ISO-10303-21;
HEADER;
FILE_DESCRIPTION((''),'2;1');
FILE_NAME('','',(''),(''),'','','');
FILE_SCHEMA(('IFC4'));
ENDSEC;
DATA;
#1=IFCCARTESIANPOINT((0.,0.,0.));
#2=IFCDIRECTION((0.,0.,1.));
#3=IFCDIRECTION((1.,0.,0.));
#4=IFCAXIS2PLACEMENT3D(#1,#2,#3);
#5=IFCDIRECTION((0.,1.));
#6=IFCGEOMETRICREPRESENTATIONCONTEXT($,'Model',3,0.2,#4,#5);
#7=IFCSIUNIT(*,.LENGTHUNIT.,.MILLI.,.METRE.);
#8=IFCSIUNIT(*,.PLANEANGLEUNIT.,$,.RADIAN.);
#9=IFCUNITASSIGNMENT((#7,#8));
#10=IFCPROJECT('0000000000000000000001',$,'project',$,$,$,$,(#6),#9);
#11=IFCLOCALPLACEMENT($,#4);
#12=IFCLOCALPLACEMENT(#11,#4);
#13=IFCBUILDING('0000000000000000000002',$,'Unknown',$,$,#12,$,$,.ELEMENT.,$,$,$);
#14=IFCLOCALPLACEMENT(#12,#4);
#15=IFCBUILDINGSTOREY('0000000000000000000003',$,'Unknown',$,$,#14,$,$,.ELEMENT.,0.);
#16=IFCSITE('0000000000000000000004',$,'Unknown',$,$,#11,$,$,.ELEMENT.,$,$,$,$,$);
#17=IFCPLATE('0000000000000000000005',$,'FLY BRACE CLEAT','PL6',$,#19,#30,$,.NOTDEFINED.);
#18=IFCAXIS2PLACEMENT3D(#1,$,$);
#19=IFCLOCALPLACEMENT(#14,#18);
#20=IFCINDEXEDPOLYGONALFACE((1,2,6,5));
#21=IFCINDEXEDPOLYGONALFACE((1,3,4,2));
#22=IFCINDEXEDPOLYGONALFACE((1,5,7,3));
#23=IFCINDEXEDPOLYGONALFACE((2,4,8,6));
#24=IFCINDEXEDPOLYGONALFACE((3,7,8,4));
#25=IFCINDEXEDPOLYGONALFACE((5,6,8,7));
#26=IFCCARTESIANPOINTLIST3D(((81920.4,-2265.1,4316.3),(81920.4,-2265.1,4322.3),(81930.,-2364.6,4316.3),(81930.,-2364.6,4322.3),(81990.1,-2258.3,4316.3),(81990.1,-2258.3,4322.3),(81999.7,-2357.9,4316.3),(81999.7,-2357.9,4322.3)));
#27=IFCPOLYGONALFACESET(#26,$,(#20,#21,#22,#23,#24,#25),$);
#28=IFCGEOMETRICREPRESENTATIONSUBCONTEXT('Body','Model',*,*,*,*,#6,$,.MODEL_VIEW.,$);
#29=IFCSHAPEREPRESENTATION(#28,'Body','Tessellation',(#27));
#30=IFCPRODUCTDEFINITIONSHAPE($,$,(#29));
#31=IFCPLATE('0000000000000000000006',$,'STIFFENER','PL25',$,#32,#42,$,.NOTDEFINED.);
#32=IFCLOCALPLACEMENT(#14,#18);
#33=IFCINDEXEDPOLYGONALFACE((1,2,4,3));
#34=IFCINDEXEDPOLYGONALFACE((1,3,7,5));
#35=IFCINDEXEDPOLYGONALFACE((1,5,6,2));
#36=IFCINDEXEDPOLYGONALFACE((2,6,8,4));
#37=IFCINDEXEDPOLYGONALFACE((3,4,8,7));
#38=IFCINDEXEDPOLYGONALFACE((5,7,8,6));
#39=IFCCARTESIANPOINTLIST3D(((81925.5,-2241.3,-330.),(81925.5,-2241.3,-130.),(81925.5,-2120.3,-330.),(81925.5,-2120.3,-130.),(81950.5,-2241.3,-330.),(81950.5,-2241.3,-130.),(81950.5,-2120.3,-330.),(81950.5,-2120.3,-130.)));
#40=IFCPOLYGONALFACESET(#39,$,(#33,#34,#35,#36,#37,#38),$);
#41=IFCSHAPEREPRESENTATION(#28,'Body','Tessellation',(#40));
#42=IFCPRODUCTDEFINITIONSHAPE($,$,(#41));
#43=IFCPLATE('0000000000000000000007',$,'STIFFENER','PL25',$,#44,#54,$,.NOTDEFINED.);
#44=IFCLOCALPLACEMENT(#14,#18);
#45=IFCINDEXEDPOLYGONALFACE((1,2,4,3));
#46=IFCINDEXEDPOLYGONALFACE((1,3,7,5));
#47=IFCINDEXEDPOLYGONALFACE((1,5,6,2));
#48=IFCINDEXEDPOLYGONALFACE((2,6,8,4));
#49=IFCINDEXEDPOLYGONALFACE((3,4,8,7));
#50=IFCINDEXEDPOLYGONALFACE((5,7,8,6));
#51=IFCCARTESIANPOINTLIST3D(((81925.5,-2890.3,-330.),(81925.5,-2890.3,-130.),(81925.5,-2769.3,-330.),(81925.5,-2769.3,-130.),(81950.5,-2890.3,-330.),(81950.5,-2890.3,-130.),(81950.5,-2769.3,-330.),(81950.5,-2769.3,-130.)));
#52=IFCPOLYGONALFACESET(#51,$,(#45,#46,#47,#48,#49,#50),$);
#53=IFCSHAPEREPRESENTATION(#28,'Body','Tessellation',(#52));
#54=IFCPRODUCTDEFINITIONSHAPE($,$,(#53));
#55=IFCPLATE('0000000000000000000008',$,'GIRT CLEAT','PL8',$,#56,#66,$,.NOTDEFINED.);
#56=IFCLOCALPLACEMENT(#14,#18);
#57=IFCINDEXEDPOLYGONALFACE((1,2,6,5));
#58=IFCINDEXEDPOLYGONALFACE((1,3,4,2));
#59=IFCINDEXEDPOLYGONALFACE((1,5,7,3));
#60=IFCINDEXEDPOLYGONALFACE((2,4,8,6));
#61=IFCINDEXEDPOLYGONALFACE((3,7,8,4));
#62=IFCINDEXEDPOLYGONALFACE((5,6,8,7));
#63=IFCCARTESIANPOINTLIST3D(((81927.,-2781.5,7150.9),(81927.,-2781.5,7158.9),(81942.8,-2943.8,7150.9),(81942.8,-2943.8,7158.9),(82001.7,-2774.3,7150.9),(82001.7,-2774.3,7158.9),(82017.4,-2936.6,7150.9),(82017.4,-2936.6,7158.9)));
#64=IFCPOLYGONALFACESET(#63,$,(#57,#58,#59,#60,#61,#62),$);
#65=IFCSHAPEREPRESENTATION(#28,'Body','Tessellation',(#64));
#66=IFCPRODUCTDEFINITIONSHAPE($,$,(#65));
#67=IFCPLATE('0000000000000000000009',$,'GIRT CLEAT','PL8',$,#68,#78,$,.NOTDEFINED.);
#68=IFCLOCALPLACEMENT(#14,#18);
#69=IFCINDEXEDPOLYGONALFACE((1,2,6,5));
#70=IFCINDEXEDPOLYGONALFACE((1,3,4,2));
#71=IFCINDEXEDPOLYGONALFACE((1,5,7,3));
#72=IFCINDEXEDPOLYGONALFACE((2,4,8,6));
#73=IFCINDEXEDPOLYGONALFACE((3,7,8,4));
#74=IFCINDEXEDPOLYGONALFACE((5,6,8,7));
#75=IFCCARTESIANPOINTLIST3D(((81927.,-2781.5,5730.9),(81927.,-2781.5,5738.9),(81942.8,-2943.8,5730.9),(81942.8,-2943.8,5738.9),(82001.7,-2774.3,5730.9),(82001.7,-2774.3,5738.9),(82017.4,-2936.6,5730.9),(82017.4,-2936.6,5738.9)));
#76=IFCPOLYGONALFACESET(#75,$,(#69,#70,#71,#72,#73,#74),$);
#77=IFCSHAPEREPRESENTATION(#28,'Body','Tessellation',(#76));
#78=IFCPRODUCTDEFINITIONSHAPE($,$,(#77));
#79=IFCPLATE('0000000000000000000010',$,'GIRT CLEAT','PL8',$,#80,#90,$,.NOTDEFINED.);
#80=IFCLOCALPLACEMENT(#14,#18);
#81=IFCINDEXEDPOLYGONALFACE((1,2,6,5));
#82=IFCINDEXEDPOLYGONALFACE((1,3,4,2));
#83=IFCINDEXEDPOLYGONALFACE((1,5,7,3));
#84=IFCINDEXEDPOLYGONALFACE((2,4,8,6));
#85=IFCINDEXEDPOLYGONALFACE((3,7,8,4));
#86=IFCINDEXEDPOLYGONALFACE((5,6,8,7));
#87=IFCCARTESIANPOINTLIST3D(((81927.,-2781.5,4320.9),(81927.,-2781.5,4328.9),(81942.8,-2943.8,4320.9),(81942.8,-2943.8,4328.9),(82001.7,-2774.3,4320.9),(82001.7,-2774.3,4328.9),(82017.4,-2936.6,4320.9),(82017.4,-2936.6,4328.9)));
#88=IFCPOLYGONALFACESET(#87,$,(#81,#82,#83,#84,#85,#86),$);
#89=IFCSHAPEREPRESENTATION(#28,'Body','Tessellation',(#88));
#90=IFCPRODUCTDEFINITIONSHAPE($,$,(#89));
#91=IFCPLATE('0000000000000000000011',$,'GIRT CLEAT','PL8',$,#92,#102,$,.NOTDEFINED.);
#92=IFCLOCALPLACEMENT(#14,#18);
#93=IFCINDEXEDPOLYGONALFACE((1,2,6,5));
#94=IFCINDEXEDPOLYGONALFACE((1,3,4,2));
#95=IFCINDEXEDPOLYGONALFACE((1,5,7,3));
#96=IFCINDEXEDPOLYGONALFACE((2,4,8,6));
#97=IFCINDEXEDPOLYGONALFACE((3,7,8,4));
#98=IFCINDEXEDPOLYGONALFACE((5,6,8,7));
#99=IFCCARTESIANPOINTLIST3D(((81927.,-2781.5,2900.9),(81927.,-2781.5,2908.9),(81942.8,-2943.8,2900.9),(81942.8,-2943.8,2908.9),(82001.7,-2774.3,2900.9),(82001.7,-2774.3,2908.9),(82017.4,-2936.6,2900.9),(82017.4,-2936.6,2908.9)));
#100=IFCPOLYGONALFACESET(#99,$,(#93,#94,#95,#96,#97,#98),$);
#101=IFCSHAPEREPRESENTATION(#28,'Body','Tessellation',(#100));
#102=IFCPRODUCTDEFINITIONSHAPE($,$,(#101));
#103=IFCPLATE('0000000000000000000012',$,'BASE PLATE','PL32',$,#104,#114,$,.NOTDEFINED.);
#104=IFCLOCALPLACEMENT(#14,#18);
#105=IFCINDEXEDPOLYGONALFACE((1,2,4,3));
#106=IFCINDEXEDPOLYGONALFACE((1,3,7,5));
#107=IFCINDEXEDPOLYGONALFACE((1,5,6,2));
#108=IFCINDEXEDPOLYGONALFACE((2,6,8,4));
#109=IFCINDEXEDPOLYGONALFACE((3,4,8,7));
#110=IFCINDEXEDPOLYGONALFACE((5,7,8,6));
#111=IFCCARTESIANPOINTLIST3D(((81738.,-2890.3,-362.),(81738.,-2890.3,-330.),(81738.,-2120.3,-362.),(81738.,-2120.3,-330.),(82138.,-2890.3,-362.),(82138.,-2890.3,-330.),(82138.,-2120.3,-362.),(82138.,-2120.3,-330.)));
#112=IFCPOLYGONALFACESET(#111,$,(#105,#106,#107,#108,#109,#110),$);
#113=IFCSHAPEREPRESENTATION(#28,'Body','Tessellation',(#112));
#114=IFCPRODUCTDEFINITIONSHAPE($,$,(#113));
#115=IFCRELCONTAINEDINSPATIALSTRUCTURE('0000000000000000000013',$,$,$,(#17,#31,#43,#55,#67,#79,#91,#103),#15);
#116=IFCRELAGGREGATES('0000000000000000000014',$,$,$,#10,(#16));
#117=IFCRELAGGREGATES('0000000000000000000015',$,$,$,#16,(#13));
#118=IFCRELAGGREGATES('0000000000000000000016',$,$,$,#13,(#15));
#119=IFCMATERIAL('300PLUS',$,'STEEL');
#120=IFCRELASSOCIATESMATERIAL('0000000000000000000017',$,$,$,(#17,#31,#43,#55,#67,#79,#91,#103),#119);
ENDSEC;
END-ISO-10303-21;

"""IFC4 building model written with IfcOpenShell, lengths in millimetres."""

from ifc_helpers import new_model, si_unit, direction, frame, origin_with_axes, place, context, subcontext, project, spatial, line, indexed_curve, outline, extrude, material, element, save


model = new_model("IFC4")

# Units and contexts
model_context = context("Model", 3, precision=0.2, world=origin_with_axes(), true_north=direction((0.0, 1.0)))
body_context = subcontext(model_context, "Body", "Model", "MODEL_VIEW")
ifc_project = project(units=[si_unit("LENGTHUNIT", "METRE", prefix="MILLI"), si_unit("PLANEANGLEUNIT", "RADIAN")], contexts=[model_context])

# Site, building, storey
site_placement = place(None, origin_with_axes())
site = spatial("IfcSite", under=ifc_project, at=site_placement, Name="Unknown", CompositionType="ELEMENT")
building_placement = place(site_placement, origin_with_axes())
building = spatial("IfcBuilding", under=site, at=building_placement, Name="Unknown", CompositionType="ELEMENT")
storey_placement = place(building_placement, origin_with_axes())
storey = spatial("IfcBuildingStorey", under=building, at=storey_placement, Name="Unknown", CompositionType="ELEMENT", Elevation=0.0)

# Shared definitions
ifc_material_1 = material(Name="300PLUS", Category="STEEL")

# Plates
plate_1_placement = place(storey_placement, frame((81930.0, -2364.6, 4319.3), z_axis=(0.0, 0.0, 1.0), x_axis=(0.995412, 0.095685, 0.0)))
element("IfcPlate", 1, at=plate_1_placement, inside=storey, material=ifc_material_1, Name="FLY BRACE CLEAT", Description="PL6", PredefinedType="NOTDEFINED", context=body_context, shape_type="SolidModel", body=[
    extrude(outline(indexed_curve([(0.0, 0.0), (70.0, 0.0), (70.0, 100.1), (0.0, 100.0)], segments=[line(1, 2, 3, 4, 1)])), frame((0.0, 0.0, 3.0), z_axis=(0.0, 0.0, 1.0), x_axis=(1.0, 0.0, 0.0)), (0.0, 0.0, -1.0), 6.0),
])
for number, where, z_axis, x_axis, name in (
    (2, (81938.0, -2241.3, -330.0), (1.0, 0.0, 0.0), (0.0, 1.0, 0.0), "STIFFENER"),
    (3, (81938.0, -2769.3, -130.0), (1.0, 0.0, 0.0), (0.0, -1.0, 0.0), "STIFFENER"),
):
    element("IfcPlate", number, at=place(storey_placement, frame(where, z_axis=z_axis, x_axis=x_axis)), inside=storey, material=ifc_material_1, Name=name, Description="PL25", PredefinedType="NOTDEFINED", context=body_context, shape_type="SolidModel", body=[
        extrude(outline(indexed_curve([(0.0, 0.0), (121.0, 0.0), (121.0, 200.0), (0.0, 200.0)], segments=[line(1, 2, 3, 4, 1)])), frame((0.0, 0.0, 12.5), z_axis=(0.0, 0.0, 1.0), x_axis=(1.0, 0.0, 0.0)), (0.0, 0.0, -1.0), 25.0),
    ])
for number, where, z_axis, x_axis, name in (
    (4, (81942.8, -2943.8, 7154.9), (0.0, 0.0, 1.0), (0.995375, 0.096068, 0.0), "GIRT CLEAT"),
    (5, (81942.8, -2943.8, 5734.9), (0.0, 0.0, 1.0), (0.995375, 0.096068, 0.0), "GIRT CLEAT"),
    (6, (81942.8, -2943.8, 4324.9), (0.0, 0.0, 1.0), (0.995375, 0.096068, 0.0), "GIRT CLEAT"),
    (7, (81942.8, -2943.8, 2904.9), (0.0, 0.0, 1.0), (0.995375, 0.096068, 0.0), "GIRT CLEAT"),
):
    element("IfcPlate", number, at=place(storey_placement, frame(where, z_axis=z_axis, x_axis=x_axis)), inside=storey, material=ifc_material_1, Name=name, Description="PL8", PredefinedType="NOTDEFINED", context=body_context, shape_type="SolidModel", body=[
        extrude(outline(indexed_curve([(0.0, 0.0), (74.9, 0.0), (74.9, 163.1), (-0.1, 163.1)], segments=[line(1, 2, 3, 4, 1)])), frame((0.0, 0.0, 4.0), z_axis=(0.0, 0.0, 1.0), x_axis=(1.0, 0.0, 0.0)), (0.0, 0.0, -1.0), 8.0),
    ])
plate_2_placement = place(storey_placement, frame((82138.0, -2890.3, -346.0), z_axis=(0.0, 0.0, 1.0), x_axis=(0.0, 1.0, 0.0)))
element("IfcPlate", 8, at=plate_2_placement, inside=storey, material=ifc_material_1, Name="BASE PLATE", Description="PL32", PredefinedType="NOTDEFINED", context=body_context, shape_type="SolidModel", body=[
    extrude(outline(indexed_curve([(0.0, 0.0), (770.0, 0.0), (770.0, 400.0), (0.0, 400.0)], segments=[line(1, 2, 3, 4, 1)])), frame((0.0, 0.0, 16.0), z_axis=(0.0, 0.0, 1.0), x_axis=(1.0, 0.0, 0.0)), (0.0, 0.0, -1.0), 32.0),
])

save(model, "model.ifc")
